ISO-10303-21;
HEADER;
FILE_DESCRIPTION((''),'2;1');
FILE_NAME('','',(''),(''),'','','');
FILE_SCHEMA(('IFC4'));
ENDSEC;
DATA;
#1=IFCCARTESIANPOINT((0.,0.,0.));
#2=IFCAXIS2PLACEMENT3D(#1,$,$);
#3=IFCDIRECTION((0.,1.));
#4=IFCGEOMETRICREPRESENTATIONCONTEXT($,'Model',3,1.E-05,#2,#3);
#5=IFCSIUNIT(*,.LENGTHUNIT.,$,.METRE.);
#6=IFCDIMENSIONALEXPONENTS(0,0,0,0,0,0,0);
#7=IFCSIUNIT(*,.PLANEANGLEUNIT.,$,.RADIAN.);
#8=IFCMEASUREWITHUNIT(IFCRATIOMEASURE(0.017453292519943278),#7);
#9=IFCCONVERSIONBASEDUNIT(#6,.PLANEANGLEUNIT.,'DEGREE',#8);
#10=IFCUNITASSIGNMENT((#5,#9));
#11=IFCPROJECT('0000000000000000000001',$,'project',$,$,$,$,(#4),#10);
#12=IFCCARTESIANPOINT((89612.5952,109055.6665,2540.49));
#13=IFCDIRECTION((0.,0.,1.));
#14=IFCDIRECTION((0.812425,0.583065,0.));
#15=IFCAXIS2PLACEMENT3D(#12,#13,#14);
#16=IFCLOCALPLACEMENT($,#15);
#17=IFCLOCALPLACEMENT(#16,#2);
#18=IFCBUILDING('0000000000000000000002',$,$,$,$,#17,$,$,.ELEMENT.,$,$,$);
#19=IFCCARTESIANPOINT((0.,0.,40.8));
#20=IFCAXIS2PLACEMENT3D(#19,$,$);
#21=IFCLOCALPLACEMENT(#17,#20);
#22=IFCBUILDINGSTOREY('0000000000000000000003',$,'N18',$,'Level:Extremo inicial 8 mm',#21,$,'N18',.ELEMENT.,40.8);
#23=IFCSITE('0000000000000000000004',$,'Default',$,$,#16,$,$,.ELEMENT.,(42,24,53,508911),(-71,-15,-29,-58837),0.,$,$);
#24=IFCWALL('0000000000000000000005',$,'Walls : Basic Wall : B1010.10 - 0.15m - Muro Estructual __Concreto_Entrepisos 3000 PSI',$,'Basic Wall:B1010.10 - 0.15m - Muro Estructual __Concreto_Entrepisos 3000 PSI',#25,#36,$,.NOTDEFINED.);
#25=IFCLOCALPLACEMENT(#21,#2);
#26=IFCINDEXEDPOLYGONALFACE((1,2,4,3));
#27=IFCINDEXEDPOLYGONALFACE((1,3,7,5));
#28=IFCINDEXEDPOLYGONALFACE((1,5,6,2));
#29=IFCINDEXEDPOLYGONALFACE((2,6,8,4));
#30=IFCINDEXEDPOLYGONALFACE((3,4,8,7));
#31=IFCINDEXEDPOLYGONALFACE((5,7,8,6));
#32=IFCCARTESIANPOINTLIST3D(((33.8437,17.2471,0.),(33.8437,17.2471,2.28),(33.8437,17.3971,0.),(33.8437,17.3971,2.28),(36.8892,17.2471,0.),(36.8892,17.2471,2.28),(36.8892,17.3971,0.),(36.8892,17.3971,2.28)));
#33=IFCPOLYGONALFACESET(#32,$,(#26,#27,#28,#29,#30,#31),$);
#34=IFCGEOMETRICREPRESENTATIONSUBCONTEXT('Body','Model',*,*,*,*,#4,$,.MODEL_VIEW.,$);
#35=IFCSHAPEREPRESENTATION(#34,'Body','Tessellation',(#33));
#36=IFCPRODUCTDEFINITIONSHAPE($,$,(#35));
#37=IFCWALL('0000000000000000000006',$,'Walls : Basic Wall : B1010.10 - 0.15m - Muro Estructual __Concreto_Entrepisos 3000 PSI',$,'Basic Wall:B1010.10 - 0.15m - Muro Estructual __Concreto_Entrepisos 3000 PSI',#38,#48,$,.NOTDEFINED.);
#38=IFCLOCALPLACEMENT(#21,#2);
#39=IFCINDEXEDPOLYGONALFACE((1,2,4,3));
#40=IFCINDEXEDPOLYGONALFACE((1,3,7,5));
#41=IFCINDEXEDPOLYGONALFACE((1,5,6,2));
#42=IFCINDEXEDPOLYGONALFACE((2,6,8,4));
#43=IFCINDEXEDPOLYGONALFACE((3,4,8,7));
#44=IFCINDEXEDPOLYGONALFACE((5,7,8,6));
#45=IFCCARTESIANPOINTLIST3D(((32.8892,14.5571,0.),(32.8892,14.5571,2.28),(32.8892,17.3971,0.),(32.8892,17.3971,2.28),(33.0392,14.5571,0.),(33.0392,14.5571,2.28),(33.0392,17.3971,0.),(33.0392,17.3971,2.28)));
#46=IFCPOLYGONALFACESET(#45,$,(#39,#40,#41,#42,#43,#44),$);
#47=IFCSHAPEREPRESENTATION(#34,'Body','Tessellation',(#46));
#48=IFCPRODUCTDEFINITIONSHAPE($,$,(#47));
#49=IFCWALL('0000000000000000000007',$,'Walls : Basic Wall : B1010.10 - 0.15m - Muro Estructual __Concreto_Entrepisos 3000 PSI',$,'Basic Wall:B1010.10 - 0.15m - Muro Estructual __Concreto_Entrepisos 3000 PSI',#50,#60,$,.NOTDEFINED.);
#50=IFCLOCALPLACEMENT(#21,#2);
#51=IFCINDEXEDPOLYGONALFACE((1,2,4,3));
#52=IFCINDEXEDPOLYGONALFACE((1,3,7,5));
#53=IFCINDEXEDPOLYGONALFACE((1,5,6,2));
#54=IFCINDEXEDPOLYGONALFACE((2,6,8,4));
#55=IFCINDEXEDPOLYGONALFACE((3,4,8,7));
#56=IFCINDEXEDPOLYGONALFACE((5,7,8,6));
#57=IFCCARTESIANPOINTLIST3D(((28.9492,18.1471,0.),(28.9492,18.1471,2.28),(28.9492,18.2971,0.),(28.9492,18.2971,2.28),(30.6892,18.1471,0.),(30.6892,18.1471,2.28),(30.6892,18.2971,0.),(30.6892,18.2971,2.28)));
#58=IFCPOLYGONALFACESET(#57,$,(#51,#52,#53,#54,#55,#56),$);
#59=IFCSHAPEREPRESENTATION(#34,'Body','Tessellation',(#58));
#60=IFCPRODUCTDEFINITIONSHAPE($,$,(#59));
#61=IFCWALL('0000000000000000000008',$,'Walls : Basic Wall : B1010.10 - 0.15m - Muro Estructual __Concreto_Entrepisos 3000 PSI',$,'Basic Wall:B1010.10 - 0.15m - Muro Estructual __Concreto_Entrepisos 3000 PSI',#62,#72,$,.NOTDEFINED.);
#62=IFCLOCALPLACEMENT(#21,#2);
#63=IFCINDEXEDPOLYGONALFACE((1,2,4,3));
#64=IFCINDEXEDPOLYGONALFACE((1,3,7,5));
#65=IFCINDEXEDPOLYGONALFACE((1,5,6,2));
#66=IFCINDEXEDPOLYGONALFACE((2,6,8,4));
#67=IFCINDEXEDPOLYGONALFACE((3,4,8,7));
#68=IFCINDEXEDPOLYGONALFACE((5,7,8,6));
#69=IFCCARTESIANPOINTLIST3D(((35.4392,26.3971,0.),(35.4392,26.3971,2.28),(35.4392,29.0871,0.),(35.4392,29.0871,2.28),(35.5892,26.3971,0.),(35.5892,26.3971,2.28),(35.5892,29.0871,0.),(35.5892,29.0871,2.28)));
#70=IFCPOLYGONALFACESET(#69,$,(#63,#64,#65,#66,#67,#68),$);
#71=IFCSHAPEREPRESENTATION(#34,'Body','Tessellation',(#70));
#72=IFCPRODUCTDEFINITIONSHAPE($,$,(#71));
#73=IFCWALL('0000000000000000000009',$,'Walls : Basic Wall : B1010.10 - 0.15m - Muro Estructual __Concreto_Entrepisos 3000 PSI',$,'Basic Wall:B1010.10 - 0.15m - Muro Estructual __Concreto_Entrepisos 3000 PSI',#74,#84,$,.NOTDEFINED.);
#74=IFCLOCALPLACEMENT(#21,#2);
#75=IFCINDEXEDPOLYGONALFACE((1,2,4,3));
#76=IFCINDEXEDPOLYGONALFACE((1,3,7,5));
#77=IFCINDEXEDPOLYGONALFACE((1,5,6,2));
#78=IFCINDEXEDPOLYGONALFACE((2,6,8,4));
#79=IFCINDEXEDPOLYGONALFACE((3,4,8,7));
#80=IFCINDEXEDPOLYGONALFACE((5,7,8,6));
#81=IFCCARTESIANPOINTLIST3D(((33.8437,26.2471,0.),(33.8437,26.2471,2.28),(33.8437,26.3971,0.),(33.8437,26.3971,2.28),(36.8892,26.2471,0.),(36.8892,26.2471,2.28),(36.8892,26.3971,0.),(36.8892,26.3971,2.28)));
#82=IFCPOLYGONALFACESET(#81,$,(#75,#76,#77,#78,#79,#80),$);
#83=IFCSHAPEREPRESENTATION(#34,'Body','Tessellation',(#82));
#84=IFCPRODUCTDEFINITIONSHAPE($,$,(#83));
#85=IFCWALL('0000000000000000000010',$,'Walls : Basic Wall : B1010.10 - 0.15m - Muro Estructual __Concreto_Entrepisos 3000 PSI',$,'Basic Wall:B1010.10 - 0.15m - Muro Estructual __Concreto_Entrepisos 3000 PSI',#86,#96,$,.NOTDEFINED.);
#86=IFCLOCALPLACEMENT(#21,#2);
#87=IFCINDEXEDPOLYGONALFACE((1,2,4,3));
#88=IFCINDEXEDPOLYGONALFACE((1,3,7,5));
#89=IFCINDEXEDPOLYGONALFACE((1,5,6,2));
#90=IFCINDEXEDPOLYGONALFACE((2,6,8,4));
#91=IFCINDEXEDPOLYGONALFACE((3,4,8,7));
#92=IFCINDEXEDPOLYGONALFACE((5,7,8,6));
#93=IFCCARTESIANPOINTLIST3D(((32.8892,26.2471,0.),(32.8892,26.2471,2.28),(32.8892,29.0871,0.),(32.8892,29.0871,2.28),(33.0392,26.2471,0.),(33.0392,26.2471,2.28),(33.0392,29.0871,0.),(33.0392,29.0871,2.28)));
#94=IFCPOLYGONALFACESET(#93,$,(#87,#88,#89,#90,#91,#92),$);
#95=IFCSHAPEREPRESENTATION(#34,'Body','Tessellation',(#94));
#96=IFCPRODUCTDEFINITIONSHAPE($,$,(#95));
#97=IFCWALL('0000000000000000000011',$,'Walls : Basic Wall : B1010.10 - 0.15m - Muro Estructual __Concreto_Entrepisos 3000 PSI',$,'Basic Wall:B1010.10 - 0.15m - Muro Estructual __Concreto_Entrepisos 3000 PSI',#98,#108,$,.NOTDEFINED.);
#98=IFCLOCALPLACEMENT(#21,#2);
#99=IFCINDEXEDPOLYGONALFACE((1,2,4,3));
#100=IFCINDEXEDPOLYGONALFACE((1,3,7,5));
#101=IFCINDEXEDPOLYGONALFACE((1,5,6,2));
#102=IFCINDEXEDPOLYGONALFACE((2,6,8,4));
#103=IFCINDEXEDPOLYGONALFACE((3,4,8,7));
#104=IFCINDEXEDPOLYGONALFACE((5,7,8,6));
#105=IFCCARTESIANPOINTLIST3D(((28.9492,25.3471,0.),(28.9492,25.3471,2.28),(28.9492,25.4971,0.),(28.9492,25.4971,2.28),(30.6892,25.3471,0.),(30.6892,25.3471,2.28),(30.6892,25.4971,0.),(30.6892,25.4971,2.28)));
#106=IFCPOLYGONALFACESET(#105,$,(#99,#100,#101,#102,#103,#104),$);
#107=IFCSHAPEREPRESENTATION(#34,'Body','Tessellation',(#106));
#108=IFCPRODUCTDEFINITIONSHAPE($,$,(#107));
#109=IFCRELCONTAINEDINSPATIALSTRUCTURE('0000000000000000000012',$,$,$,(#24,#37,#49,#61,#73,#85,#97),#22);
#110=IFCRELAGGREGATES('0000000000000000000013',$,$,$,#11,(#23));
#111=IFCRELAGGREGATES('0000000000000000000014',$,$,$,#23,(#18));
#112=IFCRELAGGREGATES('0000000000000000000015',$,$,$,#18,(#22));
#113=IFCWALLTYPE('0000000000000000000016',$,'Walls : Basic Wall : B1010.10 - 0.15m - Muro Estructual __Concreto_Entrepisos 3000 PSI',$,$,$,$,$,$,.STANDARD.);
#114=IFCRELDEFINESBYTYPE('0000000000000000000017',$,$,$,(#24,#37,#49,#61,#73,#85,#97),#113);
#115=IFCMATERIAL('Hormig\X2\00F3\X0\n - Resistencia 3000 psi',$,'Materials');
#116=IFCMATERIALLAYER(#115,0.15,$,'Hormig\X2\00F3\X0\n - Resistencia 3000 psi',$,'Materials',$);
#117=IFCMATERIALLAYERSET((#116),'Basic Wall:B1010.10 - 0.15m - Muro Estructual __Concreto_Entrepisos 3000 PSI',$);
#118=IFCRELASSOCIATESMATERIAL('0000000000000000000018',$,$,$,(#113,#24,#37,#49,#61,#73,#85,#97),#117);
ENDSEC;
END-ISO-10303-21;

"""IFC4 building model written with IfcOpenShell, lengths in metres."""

from ifc_helpers import new_model, entity, si_unit, converted_unit, direction, frame, frame_2d, origin, place, context, subcontext, project, spatial, rectangle, extrude, material, layer, layer_set, layer_usage, type_object, element, save


model = new_model("IFC4")

# Units and contexts
model_context = context("Model", 3, precision=1e-05, world=origin(), true_north=direction((0.0, 1.0)))
body_context = subcontext(model_context, "Body", "Model", "MODEL_VIEW")
ifc_project = project(units=[si_unit("LENGTHUNIT", "METRE"), converted_unit("PLANEANGLEUNIT", "DEGREE", entity("IfcRatioMeasure", 0.017453292519943278), si_unit("PLANEANGLEUNIT", "RADIAN"), dimensions=[0, 0, 0, 0, 0, 0, 0])], contexts=[model_context])

# Site, building, storey
site_placement = place(None, frame((89612.5952, 109055.6665, 2540.49), z_axis=(0.0, 0.0, 1.0), x_axis=(0.812425, 0.583065, 0.0)))
site = spatial("IfcSite", under=ifc_project, at=site_placement, Name="Default", CompositionType="ELEMENT", RefLatitude=(42, 24, 53, 508911), RefLongitude=(-71, -15, -29, -58837), RefElevation=0.0)
building_placement = place(site_placement, origin())
building = spatial("IfcBuilding", under=site, at=building_placement, CompositionType="ELEMENT")
storey_placement = place(building_placement, frame((0.0, 0.0, 40.8)))
storey = spatial("IfcBuildingStorey", under=building, at=storey_placement, Name="N18", ObjectType="Level:Extremo inicial 8 mm", LongName="N18", CompositionType="ELEMENT", Elevation=40.8)

# Walls
ifc_material = material(Name="Hormigón - Resistencia 3000 psi", Category="Materials")
ifc_layer_1 = layer(ifc_material, 0.15, Name="Hormigón - Resistencia 3000 psi", Category="Materials")
ifc_layer_set_1 = layer_set([ifc_layer_1], Name="Basic Wall:B1010.10 - 0.15m - Muro Estructual __Concreto_Entrepisos 3000 PSI")
wall_type_1 = type_object("IfcWallType", Name="Walls : Basic Wall : B1010.10 - 0.15m - Muro Estructual __Concreto_Entrepisos 3000 PSI", PredefinedType="STANDARD", material=ifc_layer_set_1)
ifc_layer_usage_1 = layer_usage(ifc_layer_set_1, "AXIS2", "NEGATIVE", 0.075)
wall_1_placement = place(storey_placement, frame((36.8892, 17.3221, 0.0), z_axis=(0.0, 0.0, 1.0), x_axis=(-1.0, 0.0, 0.0)))
element("IfcWall", 1, at=wall_1_placement, inside=storey, type_object=wall_type_1, material=ifc_layer_usage_1, Name="Walls : Basic Wall : B1010.10 - 0.15m - Muro Estructual __Concreto_Entrepisos 3000 PSI", ObjectType="Basic Wall:B1010.10 - 0.15m - Muro Estructual __Concreto_Entrepisos 3000 PSI", PredefinedType="NOTDEFINED", context=body_context, shape_type="SweptSolid", body=[
    extrude(rectangle(XDim=3.0455, YDim=0.15, at=frame_2d((1.5228, 0.0), x_axis=(-1.0, 0.0))), origin(), (0.0, 0.0, 1.0), 2.28),
])
ifc_layer_usage_2 = layer_usage(ifc_layer_set_1, "AXIS2", "NEGATIVE", 0.075)
wall_2_placement = place(storey_placement, frame((32.9642, 14.5571, 0.0), z_axis=(0.0, 0.0, 1.0), x_axis=(0.0, 1.0, 0.0)))
element("IfcWall", 2, at=wall_2_placement, inside=storey, type_object=wall_type_1, material=ifc_layer_usage_2, Name="Walls : Basic Wall : B1010.10 - 0.15m - Muro Estructual __Concreto_Entrepisos 3000 PSI", ObjectType="Basic Wall:B1010.10 - 0.15m - Muro Estructual __Concreto_Entrepisos 3000 PSI", PredefinedType="NOTDEFINED", context=body_context, shape_type="SweptSolid", body=[
    extrude(rectangle(XDim=2.84, YDim=0.15, at=frame_2d((1.42, 0.0), x_axis=(-1.0, 0.0))), origin(), (0.0, 0.0, 1.0), 2.28),
])
ifc_layer_usage_3 = layer_usage(ifc_layer_set_1, "AXIS2", "NEGATIVE", 0.075)
wall_3_placement = place(storey_placement, frame((30.6892, 18.2221, 0.0), z_axis=(0.0, 0.0, 1.0), x_axis=(-1.0, 0.0, 0.0)))
element("IfcWall", 3, at=wall_3_placement, inside=storey, type_object=wall_type_1, material=ifc_layer_usage_3, Name="Walls : Basic Wall : B1010.10 - 0.15m - Muro Estructual __Concreto_Entrepisos 3000 PSI", ObjectType="Basic Wall:B1010.10 - 0.15m - Muro Estructual __Concreto_Entrepisos 3000 PSI", PredefinedType="NOTDEFINED", context=body_context, shape_type="SweptSolid", body=[
    extrude(rectangle(XDim=1.74, YDim=0.15, at=frame_2d((0.87, 0.0), x_axis=(-1.0, 0.0))), origin(), (0.0, 0.0, 1.0), 2.28),
])
ifc_layer_usage_4 = layer_usage(ifc_layer_set_1, "AXIS2", "POSITIVE", -0.075)
wall_4_placement = place(storey_placement, frame((35.5142, 29.0871, 0.0), z_axis=(0.0, 0.0, 1.0), x_axis=(0.0, -1.0, 0.0)))
element("IfcWall", 4, at=wall_4_placement, inside=storey, type_object=wall_type_1, material=ifc_layer_usage_4, Name="Walls : Basic Wall : B1010.10 - 0.15m - Muro Estructual __Concreto_Entrepisos 3000 PSI", ObjectType="Basic Wall:B1010.10 - 0.15m - Muro Estructual __Concreto_Entrepisos 3000 PSI", PredefinedType="NOTDEFINED", context=body_context, shape_type="SweptSolid", body=[
    extrude(rectangle(XDim=2.69, YDim=0.15, at=frame_2d((1.345, 0.0), x_axis=(-1.0, 0.0))), origin(), (0.0, 0.0, 1.0), 2.28),
])
ifc_layer_usage_5 = layer_usage(ifc_layer_set_1, "AXIS2", "POSITIVE", -0.075)
wall_5_placement = place(storey_placement, frame((36.8892, 26.3221, 0.0), z_axis=(0.0, 0.0, 1.0), x_axis=(-1.0, 0.0, 0.0)))
element("IfcWall", 5, at=wall_5_placement, inside=storey, type_object=wall_type_1, material=ifc_layer_usage_5, Name="Walls : Basic Wall : B1010.10 - 0.15m - Muro Estructual __Concreto_Entrepisos 3000 PSI", ObjectType="Basic Wall:B1010.10 - 0.15m - Muro Estructual __Concreto_Entrepisos 3000 PSI", PredefinedType="NOTDEFINED", context=body_context, shape_type="SweptSolid", body=[
    extrude(rectangle(XDim=3.0455, YDim=0.15, at=frame_2d((1.5228, 0.0), x_axis=(-1.0, 0.0))), origin(), (0.0, 0.0, 1.0), 2.28),
])
ifc_layer_usage_6 = layer_usage(ifc_layer_set_1, "AXIS2", "POSITIVE", -0.075)
wall_6_placement = place(storey_placement, frame((32.9642, 29.0871, 0.0), z_axis=(0.0, 0.0, 1.0), x_axis=(0.0, -1.0, 0.0)))
element("IfcWall", 6, at=wall_6_placement, inside=storey, type_object=wall_type_1, material=ifc_layer_usage_6, Name="Walls : Basic Wall : B1010.10 - 0.15m - Muro Estructual __Concreto_Entrepisos 3000 PSI", ObjectType="Basic Wall:B1010.10 - 0.15m - Muro Estructual __Concreto_Entrepisos 3000 PSI", PredefinedType="NOTDEFINED", context=body_context, shape_type="SweptSolid", body=[
    extrude(rectangle(XDim=2.84, YDim=0.15, at=frame_2d((1.42, 0.0), x_axis=(-1.0, 0.0))), origin(), (0.0, 0.0, 1.0), 2.28),
])
ifc_layer_usage_7 = layer_usage(ifc_layer_set_1, "AXIS2", "POSITIVE", -0.075)
wall_7_placement = place(storey_placement, frame((30.6892, 25.4221, 0.0), z_axis=(0.0, 0.0, 1.0), x_axis=(-1.0, 0.0, 0.0)))
element("IfcWall", 7, at=wall_7_placement, inside=storey, type_object=wall_type_1, material=ifc_layer_usage_7, Name="Walls : Basic Wall : B1010.10 - 0.15m - Muro Estructual __Concreto_Entrepisos 3000 PSI", ObjectType="Basic Wall:B1010.10 - 0.15m - Muro Estructual __Concreto_Entrepisos 3000 PSI", PredefinedType="NOTDEFINED", context=body_context, shape_type="SweptSolid", body=[
    extrude(rectangle(XDim=1.74, YDim=0.15, at=frame_2d((0.87, 0.0), x_axis=(-1.0, 0.0))), origin(), (0.0, 0.0, 1.0), 2.28),
])

save(model, "model.ifc")
